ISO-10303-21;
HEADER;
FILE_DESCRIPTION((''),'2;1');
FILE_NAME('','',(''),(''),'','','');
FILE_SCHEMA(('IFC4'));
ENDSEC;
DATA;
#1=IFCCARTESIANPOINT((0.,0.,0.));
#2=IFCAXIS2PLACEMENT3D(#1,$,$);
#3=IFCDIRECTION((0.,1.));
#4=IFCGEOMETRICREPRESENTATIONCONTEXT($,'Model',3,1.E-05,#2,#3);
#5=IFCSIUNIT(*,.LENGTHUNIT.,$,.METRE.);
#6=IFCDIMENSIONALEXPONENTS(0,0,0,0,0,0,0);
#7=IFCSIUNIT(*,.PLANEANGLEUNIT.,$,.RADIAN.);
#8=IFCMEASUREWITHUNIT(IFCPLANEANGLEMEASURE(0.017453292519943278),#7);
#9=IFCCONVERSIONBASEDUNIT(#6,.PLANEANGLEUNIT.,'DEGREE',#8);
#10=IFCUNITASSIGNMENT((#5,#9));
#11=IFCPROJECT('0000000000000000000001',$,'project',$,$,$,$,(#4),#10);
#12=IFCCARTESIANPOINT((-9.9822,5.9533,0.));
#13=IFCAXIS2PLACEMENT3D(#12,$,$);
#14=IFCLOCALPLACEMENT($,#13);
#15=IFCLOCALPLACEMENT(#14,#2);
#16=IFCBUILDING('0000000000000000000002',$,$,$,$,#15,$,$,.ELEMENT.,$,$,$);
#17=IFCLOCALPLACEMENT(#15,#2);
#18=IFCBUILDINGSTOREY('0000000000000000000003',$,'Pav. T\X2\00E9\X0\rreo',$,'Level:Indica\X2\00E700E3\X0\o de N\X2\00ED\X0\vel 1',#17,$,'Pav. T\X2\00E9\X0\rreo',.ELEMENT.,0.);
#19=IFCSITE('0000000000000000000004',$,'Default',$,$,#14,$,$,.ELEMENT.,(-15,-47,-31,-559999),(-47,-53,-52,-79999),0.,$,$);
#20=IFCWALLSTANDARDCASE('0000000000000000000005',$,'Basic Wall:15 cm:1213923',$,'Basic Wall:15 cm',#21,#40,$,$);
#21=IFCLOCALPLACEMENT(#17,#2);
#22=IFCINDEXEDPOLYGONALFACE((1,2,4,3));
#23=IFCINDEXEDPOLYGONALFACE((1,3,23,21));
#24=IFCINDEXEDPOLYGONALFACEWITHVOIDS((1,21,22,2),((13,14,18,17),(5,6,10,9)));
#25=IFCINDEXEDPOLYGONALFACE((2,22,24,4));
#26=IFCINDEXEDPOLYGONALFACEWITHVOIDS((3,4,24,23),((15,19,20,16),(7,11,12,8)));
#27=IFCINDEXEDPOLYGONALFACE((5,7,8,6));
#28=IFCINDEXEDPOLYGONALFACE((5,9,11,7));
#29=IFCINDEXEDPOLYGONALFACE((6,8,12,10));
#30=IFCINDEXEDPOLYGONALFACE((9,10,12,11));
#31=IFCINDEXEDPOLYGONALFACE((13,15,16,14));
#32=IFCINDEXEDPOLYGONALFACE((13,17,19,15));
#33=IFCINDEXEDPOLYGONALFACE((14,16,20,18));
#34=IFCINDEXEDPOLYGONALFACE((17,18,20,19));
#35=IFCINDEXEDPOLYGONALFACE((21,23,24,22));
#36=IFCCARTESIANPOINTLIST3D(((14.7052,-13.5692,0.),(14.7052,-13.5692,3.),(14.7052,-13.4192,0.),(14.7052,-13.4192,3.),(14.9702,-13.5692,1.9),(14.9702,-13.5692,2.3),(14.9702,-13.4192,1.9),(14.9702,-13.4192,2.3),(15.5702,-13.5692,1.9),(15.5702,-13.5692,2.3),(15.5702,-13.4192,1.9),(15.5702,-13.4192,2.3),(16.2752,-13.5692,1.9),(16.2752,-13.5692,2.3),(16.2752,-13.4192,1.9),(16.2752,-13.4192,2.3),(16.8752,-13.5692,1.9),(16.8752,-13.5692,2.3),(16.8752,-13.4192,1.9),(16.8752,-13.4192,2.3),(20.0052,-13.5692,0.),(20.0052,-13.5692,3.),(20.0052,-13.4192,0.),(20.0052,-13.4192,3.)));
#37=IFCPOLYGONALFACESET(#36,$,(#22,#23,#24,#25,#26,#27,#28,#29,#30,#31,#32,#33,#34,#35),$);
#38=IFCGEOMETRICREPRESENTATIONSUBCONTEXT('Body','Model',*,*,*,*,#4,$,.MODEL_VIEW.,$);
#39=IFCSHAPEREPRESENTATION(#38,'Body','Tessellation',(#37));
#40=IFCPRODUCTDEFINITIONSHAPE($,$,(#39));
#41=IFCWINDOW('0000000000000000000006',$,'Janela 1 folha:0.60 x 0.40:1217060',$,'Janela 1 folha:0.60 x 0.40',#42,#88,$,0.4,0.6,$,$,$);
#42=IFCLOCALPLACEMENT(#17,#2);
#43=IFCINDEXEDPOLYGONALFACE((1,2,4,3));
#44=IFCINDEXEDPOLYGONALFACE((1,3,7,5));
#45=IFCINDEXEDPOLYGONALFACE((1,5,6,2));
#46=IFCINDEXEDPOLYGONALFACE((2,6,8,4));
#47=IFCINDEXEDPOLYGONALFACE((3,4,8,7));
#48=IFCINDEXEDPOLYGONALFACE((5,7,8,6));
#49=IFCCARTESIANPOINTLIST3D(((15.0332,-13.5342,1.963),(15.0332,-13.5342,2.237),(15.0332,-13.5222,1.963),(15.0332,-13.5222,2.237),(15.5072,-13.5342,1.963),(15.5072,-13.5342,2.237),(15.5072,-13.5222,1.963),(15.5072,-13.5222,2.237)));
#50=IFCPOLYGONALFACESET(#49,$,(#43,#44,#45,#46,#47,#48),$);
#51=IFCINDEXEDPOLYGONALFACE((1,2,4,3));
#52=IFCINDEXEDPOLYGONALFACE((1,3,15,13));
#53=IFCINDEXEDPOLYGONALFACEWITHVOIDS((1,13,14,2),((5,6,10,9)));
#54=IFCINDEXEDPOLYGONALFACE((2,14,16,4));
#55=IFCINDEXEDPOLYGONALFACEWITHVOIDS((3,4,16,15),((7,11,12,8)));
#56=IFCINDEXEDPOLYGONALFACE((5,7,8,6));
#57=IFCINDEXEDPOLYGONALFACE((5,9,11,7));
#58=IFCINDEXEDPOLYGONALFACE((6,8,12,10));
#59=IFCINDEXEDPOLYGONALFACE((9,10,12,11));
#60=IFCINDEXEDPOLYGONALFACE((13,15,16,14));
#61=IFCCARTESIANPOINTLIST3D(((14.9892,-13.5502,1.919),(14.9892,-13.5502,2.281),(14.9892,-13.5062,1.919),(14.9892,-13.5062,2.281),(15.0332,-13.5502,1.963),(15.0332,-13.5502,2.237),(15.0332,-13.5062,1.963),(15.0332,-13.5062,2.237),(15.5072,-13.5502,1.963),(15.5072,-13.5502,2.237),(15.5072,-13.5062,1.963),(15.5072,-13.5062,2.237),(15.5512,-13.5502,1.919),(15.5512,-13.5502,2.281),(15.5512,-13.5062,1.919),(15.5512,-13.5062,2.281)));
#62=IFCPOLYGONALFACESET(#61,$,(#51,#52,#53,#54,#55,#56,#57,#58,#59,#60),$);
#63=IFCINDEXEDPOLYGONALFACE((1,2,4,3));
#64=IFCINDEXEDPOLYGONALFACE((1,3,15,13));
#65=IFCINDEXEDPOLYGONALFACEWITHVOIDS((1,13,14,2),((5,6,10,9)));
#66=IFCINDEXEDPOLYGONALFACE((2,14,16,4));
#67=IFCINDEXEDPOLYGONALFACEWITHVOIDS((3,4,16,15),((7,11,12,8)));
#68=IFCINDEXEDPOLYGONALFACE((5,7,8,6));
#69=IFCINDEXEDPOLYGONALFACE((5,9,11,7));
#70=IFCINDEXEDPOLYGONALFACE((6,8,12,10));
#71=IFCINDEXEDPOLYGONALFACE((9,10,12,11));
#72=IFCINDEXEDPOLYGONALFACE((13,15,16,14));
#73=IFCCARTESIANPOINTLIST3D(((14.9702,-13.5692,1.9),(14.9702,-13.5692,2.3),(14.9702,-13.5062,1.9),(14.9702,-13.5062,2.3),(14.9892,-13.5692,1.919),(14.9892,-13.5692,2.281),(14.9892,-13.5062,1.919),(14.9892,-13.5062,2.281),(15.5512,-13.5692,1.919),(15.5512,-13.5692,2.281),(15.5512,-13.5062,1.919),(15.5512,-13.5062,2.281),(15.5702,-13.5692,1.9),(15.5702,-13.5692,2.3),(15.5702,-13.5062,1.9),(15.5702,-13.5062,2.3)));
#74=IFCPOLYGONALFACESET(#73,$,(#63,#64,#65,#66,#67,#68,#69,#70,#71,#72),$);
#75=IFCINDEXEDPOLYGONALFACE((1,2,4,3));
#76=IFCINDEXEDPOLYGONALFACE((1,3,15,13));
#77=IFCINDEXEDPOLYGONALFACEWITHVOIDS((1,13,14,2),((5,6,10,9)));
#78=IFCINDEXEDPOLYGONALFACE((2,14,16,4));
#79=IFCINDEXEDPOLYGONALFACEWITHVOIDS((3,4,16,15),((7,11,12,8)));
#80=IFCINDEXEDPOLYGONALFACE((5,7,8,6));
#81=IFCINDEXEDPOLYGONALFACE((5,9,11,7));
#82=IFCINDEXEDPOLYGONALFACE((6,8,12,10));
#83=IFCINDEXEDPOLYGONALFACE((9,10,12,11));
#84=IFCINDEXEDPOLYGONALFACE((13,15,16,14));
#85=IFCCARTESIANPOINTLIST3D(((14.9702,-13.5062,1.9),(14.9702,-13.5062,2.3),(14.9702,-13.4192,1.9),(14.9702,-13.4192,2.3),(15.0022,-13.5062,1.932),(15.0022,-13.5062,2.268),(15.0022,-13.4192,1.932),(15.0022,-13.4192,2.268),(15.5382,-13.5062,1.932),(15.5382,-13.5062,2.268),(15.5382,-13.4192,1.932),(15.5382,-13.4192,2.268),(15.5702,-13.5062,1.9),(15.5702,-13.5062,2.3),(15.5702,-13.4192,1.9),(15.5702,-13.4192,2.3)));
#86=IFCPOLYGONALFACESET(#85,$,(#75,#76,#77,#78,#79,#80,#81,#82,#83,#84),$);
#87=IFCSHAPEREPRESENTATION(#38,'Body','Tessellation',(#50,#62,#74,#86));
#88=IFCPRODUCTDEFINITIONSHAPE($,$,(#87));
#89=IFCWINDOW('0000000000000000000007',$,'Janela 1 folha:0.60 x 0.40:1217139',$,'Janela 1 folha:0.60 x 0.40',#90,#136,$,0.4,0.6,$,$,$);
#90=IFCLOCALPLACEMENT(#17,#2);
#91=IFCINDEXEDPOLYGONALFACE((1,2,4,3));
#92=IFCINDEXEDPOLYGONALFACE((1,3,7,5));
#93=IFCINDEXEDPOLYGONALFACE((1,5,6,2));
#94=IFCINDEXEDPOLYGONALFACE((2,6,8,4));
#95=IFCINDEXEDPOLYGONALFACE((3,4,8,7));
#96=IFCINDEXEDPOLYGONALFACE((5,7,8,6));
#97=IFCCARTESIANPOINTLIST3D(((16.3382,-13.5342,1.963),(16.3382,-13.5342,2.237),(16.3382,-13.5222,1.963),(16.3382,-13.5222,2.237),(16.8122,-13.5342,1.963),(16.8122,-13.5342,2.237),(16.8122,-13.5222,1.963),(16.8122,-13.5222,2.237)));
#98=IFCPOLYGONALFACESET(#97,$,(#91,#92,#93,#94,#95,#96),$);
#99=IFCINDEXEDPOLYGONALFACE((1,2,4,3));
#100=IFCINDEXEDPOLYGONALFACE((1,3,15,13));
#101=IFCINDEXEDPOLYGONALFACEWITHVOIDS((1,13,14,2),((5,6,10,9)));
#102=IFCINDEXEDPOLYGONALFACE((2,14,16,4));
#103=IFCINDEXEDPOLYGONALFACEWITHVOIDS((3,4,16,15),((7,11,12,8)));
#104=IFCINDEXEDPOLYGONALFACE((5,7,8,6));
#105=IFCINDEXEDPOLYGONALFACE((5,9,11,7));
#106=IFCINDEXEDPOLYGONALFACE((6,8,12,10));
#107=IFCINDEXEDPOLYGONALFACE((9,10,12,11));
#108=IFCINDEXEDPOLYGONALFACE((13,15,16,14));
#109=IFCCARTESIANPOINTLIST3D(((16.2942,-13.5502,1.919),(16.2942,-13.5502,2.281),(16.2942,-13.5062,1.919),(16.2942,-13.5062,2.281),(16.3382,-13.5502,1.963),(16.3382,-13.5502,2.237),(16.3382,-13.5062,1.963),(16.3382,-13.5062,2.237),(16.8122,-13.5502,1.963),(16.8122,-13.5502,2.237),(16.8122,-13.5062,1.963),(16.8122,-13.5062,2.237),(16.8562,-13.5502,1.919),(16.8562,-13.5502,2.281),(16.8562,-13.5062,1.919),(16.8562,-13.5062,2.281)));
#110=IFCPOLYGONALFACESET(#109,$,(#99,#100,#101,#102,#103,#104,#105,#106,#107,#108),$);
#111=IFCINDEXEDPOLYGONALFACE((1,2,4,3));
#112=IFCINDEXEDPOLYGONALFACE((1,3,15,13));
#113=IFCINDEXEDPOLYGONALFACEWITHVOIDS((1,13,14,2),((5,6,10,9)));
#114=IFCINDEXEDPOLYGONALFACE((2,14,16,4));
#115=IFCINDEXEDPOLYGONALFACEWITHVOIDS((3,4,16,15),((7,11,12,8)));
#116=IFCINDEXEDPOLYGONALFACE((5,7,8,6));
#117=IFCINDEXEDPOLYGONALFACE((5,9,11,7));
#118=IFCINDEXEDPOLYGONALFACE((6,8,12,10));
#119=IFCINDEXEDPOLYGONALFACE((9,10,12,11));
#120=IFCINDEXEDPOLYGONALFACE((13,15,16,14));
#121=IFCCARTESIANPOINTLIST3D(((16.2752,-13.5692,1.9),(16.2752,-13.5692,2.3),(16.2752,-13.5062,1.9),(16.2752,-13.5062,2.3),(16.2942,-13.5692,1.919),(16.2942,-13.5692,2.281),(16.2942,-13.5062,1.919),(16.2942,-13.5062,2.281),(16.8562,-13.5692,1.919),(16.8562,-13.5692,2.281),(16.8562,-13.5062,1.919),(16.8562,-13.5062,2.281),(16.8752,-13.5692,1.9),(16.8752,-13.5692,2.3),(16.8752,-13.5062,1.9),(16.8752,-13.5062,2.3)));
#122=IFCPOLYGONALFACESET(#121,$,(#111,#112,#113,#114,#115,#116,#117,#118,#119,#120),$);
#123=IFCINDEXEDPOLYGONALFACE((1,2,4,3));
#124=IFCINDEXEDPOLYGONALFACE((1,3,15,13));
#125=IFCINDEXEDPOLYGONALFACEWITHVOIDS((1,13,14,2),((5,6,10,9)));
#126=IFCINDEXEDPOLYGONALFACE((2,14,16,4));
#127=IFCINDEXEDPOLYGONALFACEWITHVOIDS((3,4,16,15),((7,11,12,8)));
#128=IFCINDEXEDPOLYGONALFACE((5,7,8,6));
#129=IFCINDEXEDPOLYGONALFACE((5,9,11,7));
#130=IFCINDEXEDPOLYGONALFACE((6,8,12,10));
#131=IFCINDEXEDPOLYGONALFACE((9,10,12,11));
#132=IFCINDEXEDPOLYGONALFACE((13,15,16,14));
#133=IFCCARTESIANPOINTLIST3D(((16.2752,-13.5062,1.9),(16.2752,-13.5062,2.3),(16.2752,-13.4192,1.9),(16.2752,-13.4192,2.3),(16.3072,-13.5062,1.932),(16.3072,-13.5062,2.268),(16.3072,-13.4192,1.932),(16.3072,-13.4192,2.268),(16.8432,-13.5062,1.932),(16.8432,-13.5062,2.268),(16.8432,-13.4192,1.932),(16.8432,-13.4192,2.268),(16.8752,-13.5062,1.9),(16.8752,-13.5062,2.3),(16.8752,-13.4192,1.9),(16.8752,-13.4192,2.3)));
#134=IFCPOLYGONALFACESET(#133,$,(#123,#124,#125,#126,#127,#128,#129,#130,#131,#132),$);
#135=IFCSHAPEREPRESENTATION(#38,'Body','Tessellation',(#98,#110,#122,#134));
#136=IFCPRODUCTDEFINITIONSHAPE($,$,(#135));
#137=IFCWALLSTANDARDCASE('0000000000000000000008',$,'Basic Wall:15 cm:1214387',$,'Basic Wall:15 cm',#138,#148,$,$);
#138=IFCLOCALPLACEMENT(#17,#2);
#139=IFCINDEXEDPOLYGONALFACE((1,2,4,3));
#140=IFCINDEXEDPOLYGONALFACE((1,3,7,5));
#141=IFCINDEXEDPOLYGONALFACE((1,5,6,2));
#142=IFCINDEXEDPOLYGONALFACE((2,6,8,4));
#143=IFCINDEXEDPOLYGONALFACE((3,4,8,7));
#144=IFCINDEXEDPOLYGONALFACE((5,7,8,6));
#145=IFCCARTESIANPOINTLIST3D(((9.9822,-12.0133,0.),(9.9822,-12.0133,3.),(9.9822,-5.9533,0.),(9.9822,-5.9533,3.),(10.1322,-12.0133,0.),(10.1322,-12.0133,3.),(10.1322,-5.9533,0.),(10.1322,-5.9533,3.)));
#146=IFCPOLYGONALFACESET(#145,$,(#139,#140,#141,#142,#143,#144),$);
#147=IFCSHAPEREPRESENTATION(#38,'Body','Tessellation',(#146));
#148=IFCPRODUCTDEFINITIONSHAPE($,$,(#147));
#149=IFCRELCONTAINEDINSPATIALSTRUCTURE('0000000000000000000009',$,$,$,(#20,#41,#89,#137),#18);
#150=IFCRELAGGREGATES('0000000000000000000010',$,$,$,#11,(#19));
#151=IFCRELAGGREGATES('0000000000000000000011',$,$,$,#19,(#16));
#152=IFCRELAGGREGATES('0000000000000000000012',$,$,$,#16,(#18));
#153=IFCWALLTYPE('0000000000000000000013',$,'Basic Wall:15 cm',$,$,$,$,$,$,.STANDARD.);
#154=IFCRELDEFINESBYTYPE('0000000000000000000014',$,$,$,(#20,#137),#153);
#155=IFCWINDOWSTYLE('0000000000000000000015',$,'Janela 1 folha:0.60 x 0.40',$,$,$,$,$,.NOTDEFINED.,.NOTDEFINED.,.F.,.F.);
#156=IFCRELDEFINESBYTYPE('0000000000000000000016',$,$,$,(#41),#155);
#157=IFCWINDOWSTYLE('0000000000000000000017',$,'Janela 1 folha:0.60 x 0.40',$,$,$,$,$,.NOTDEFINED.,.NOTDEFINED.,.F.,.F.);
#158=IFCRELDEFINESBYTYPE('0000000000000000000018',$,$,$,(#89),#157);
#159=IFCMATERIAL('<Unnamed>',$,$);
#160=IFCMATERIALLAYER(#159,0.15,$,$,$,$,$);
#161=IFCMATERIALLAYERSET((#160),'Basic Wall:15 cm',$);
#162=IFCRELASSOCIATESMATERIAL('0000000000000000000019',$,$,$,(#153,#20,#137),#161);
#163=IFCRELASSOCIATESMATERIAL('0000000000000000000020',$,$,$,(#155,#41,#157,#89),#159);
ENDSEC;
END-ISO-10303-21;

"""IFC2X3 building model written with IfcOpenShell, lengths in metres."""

from ifc_helpers import new_model, entity, si_unit, converted_unit, direction, frame, frame_2d, origin, origin_2d_with_axis, place, context, subcontext, project, spatial, polyline, rectangle, outline, extrude, source, transform, mapped, material, layer, layer_set, layer_usage, type_object, type_shapes, element, fill, save


model = new_model("IFC2X3")

# Units and contexts
model_context = context("Model", 3, precision=1e-05, world=origin(), true_north=direction((0.0, 1.0)))
body_context = subcontext(model_context, "Body", "Model", "MODEL_VIEW")
ifc_project = project(units=[si_unit("LENGTHUNIT", "METRE"), converted_unit("PLANEANGLEUNIT", "DEGREE", entity("IfcPlaneAngleMeasure", 0.017453292519943278), si_unit("PLANEANGLEUNIT", "RADIAN"), dimensions=[0, 0, 0, 0, 0, 0, 0])], contexts=[model_context])

# Site, building, storey
site_placement = place(None, frame((-9.9822, 5.9533, 0.0)))
site = spatial("IfcSite", under=ifc_project, at=site_placement, Name="Default", CompositionType="ELEMENT", RefLatitude=(-15, -47, -31, -559999), RefLongitude=(-47, -53, -52, -79999), RefElevation=0.0)
building_placement = place(site_placement, origin())
building = spatial("IfcBuilding", under=site, at=building_placement, CompositionType="ELEMENT")
storey_placement = place(building_placement, origin())
storey = spatial("IfcBuildingStorey", under=building, at=storey_placement, Name="Pav. Térreo", ObjectType="Level:Indicação de Nível 1", LongName="Pav. Térreo", CompositionType="ELEMENT", Elevation=0.0)

# Shared definitions
ifc_material_1 = material(Name="<Unnamed>")
ifc_layer_1 = layer(ifc_material_1, 0.15)
ifc_layer_set_1 = layer_set([ifc_layer_1], Name="Basic Wall:15 cm")
wall_type = type_object("IfcWallType", Name="Basic Wall:15 cm", PredefinedType="STANDARD", material=ifc_layer_set_1)

# Wall, openings, windows
ifc_layer_usage_1 = layer_usage(ifc_layer_set_1, "AXIS2", "NEGATIVE", 0.075)
wall_1_placement = place(storey_placement, frame((14.7052, -13.4942, 0.0)))
wall_1 = element("IfcWallStandardCase", 1, at=wall_1_placement, inside=storey, type_object=wall_type, material=ifc_layer_usage_1, Name="Basic Wall:15 cm:1213923", ObjectType="Basic Wall:15 cm", context=body_context, shape_type="SweptSolid", body=[
    extrude(rectangle(XDim=5.3, YDim=0.15, at=frame_2d((2.65, 0.0), x_axis=(-1.0, 0.0))), origin(), (0.0, 0.0, 1.0), 3.0),
])
opening_1_placement = place(wall_1_placement, frame((0.865, 0.075, 1.9)))
opening_1 = element("IfcOpeningElement", 2, at=opening_1_placement, cuts=wall_1, ObjectType="Opening", context=body_context, shape_type="SweptSolid", body=[
    extrude(rectangle(XDim=0.4, YDim=0.6, at=frame_2d((0.2, 0.3), x_axis=(1.0, 0.0))), frame((0.0, 0.0, 0.0), z_axis=(0.0, -1.0, 0.0), x_axis=(0.0, 0.0, 1.0)), (0.0, 0.0, 1.0), 0.15),
])
opening_2_placement = place(wall_1_placement, frame((2.17, 0.075, 1.9)))
opening_2 = element("IfcOpeningElement", 3, at=opening_2_placement, cuts=wall_1, ObjectType="Opening", context=body_context, shape_type="SweptSolid", body=[
    extrude(rectangle(XDim=0.4, YDim=0.6, at=frame_2d((0.2, 0.3), x_axis=(1.0, 0.0))), frame((0.0, 0.0, 0.0), z_axis=(0.0, -1.0, 0.0), x_axis=(0.0, 0.0, 1.0)), (0.0, 0.0, 1.0), 0.15),
])
window_style_1 = type_object("IfcWindowStyle", Name="Janela 1 folha:0.60 x 0.40", ConstructionType="NOTDEFINED", OperationType="NOTDEFINED", ParameterTakesPrecedence=False, Sizeable=False, material=ifc_material_1)
shared_shape_1 = source(origin(), body_context, "Body", "SweptSolid", [
    extrude(rectangle(XDim=0.474, YDim=0.012, at=origin_2d_with_axis()), frame((0.3, 0.135, 0.063), z_axis=(0.0, 0.0, 1.0), x_axis=(-1.0, 0.0, 0.0)), (0.0, 0.0, 1.0), 0.274),
    extrude(outline(polyline([(-0.281, -0.181), (0.281, -0.181), (0.281, 0.181), (-0.281, 0.181), (-0.281, -0.181)]), holes=[polyline([(-0.237, -0.137), (-0.237, 0.137), (0.237, 0.137), (0.237, -0.137), (-0.237, -0.137)])]), frame((0.3, 0.157, 0.2), z_axis=(0.0, -1.0, 0.0), x_axis=(-1.0, 0.0, 0.0)), (0.0, 0.0, 1.0), 0.044),
    extrude(outline(polyline([(-0.3, -0.2), (0.3, -0.2), (0.3, 0.2), (-0.3, 0.2), (-0.3, -0.2)]), holes=[polyline([(-0.281, -0.181), (-0.281, 0.181), (0.281, 0.181), (0.281, -0.181), (-0.281, -0.181)])]), frame((0.3, 0.176, 0.2), z_axis=(0.0, -1.0, 0.0), x_axis=(-1.0, 0.0, 0.0)), (0.0, 0.0, 1.0), 0.063),
    extrude(outline(polyline([(-0.3, -0.2), (0.3, -0.2), (0.3, 0.2), (-0.3, 0.2), (-0.3, -0.2)]), holes=[polyline([(-0.268, -0.168), (-0.268, 0.168), (0.268, 0.168), (0.268, -0.168), (-0.268, -0.168)])]), frame((0.3, 0.113, 0.2), z_axis=(0.0, -1.0, 0.0), x_axis=(-1.0, 0.0, 0.0)), (0.0, 0.0, 1.0), 0.087),
])
type_shapes(window_style_1, [shared_shape_1])
window_1_placement = place(opening_1_placement, frame((0.0, 0.026, 0.0), z_axis=(0.0, 0.0, 1.0), x_axis=(-1.0, 0.0, 0.0)))
window_1 = element("IfcWindow", 4, at=window_1_placement, inside=storey, type_object=window_style_1, material=ifc_material_1, Name="Janela 1 folha:0.60 x 0.40:1217060", ObjectType="Janela 1 folha:0.60 x 0.40", OverallHeight=0.4, OverallWidth=0.6, context=body_context, shape_type="MappedRepresentation", body=[
    mapped(shared_shape_1, transform((0.0, 0.0, 0.0), scale=1.0)),
])
fill(opening_1, window_1)
window_style_2 = type_object("IfcWindowStyle", Name="Janela 1 folha:0.60 x 0.40", ConstructionType="NOTDEFINED", OperationType="NOTDEFINED", ParameterTakesPrecedence=False, Sizeable=False, material=ifc_material_1)
shared_shape_2 = source(origin(), body_context, "Body", "SweptSolid", [
    extrude(rectangle(XDim=0.012, YDim=0.474, at=origin_2d_with_axis()), frame((0.3, 0.109, 0.063), z_axis=(0.0, 0.0, 1.0), x_axis=(0.0, -1.0, 0.0)), (0.0, 0.0, 1.0), 0.274),
    extrude(outline(polyline([(-0.281, -0.181), (0.281, -0.181), (0.281, 0.181), (-0.281, 0.181), (-0.281, -0.181)]), holes=[polyline([(-0.237, -0.137), (-0.237, 0.137), (0.237, 0.137), (0.237, -0.137), (-0.237, -0.137)])]), frame((0.3, 0.087, 0.2), z_axis=(0.0, 1.0, 0.0), x_axis=(1.0, 0.0, 0.0)), (0.0, 0.0, 1.0), 0.044),
    extrude(outline(polyline([(-0.3, -0.2), (0.3, -0.2), (0.3, 0.2), (-0.3, 0.2), (-0.3, -0.2)]), holes=[polyline([(-0.281, -0.181), (-0.281, 0.181), (0.281, 0.181), (0.281, -0.181), (-0.281, -0.181)])]), frame((0.3, 0.087, 0.2), z_axis=(0.0, 1.0, 0.0), x_axis=(1.0, 0.0, 0.0)), (0.0, 0.0, 1.0), 0.063),
    extrude(outline(polyline([(-0.3, -0.2), (0.3, -0.2), (0.3, 0.2), (-0.3, 0.2), (-0.3, -0.2)]), holes=[polyline([(-0.268, -0.168), (-0.268, 0.168), (0.268, 0.168), (0.268, -0.168), (-0.268, -0.168)])]), frame((0.3, 0.0, 0.2), z_axis=(0.0, 1.0, 0.0), x_axis=(1.0, 0.0, 0.0)), (0.0, 0.0, 1.0), 0.087),
])
type_shapes(window_style_2, [shared_shape_2])
window_2_placement = place(opening_2_placement, frame((0.0, 0.0, 0.0), z_axis=(0.0, 0.0, 1.0), x_axis=(-1.0, 0.0, 0.0)))
window_2 = element("IfcWindow", 5, at=window_2_placement, inside=storey, type_object=window_style_2, material=ifc_material_1, Name="Janela 1 folha:0.60 x 0.40:1217139", ObjectType="Janela 1 folha:0.60 x 0.40", OverallHeight=0.4, OverallWidth=0.6, context=body_context, shape_type="MappedRepresentation", body=[
    mapped(shared_shape_2, transform((0.0, 0.0, 0.0), scale=1.0)),
])
fill(opening_2, window_2)

# Wall
ifc_layer_usage_2 = layer_usage(ifc_layer_set_1, "AXIS2", "NEGATIVE", 0.075)
wall_2_placement = place(storey_placement, frame((10.0572, -12.0133, 0.0), z_axis=(0.0, 0.0, 1.0), x_axis=(0.0, 1.0, 0.0)))
element("IfcWallStandardCase", 6, at=wall_2_placement, inside=storey, type_object=wall_type, material=ifc_layer_usage_2, Name="Basic Wall:15 cm:1214387", ObjectType="Basic Wall:15 cm", context=body_context, shape_type="SweptSolid", body=[
    extrude(rectangle(XDim=6.06, YDim=0.15, at=frame_2d((3.03, 0.0), x_axis=(-1.0, 0.0))), origin(), (0.0, 0.0, 1.0), 3.0),
])

save(model, "model.ifc")
